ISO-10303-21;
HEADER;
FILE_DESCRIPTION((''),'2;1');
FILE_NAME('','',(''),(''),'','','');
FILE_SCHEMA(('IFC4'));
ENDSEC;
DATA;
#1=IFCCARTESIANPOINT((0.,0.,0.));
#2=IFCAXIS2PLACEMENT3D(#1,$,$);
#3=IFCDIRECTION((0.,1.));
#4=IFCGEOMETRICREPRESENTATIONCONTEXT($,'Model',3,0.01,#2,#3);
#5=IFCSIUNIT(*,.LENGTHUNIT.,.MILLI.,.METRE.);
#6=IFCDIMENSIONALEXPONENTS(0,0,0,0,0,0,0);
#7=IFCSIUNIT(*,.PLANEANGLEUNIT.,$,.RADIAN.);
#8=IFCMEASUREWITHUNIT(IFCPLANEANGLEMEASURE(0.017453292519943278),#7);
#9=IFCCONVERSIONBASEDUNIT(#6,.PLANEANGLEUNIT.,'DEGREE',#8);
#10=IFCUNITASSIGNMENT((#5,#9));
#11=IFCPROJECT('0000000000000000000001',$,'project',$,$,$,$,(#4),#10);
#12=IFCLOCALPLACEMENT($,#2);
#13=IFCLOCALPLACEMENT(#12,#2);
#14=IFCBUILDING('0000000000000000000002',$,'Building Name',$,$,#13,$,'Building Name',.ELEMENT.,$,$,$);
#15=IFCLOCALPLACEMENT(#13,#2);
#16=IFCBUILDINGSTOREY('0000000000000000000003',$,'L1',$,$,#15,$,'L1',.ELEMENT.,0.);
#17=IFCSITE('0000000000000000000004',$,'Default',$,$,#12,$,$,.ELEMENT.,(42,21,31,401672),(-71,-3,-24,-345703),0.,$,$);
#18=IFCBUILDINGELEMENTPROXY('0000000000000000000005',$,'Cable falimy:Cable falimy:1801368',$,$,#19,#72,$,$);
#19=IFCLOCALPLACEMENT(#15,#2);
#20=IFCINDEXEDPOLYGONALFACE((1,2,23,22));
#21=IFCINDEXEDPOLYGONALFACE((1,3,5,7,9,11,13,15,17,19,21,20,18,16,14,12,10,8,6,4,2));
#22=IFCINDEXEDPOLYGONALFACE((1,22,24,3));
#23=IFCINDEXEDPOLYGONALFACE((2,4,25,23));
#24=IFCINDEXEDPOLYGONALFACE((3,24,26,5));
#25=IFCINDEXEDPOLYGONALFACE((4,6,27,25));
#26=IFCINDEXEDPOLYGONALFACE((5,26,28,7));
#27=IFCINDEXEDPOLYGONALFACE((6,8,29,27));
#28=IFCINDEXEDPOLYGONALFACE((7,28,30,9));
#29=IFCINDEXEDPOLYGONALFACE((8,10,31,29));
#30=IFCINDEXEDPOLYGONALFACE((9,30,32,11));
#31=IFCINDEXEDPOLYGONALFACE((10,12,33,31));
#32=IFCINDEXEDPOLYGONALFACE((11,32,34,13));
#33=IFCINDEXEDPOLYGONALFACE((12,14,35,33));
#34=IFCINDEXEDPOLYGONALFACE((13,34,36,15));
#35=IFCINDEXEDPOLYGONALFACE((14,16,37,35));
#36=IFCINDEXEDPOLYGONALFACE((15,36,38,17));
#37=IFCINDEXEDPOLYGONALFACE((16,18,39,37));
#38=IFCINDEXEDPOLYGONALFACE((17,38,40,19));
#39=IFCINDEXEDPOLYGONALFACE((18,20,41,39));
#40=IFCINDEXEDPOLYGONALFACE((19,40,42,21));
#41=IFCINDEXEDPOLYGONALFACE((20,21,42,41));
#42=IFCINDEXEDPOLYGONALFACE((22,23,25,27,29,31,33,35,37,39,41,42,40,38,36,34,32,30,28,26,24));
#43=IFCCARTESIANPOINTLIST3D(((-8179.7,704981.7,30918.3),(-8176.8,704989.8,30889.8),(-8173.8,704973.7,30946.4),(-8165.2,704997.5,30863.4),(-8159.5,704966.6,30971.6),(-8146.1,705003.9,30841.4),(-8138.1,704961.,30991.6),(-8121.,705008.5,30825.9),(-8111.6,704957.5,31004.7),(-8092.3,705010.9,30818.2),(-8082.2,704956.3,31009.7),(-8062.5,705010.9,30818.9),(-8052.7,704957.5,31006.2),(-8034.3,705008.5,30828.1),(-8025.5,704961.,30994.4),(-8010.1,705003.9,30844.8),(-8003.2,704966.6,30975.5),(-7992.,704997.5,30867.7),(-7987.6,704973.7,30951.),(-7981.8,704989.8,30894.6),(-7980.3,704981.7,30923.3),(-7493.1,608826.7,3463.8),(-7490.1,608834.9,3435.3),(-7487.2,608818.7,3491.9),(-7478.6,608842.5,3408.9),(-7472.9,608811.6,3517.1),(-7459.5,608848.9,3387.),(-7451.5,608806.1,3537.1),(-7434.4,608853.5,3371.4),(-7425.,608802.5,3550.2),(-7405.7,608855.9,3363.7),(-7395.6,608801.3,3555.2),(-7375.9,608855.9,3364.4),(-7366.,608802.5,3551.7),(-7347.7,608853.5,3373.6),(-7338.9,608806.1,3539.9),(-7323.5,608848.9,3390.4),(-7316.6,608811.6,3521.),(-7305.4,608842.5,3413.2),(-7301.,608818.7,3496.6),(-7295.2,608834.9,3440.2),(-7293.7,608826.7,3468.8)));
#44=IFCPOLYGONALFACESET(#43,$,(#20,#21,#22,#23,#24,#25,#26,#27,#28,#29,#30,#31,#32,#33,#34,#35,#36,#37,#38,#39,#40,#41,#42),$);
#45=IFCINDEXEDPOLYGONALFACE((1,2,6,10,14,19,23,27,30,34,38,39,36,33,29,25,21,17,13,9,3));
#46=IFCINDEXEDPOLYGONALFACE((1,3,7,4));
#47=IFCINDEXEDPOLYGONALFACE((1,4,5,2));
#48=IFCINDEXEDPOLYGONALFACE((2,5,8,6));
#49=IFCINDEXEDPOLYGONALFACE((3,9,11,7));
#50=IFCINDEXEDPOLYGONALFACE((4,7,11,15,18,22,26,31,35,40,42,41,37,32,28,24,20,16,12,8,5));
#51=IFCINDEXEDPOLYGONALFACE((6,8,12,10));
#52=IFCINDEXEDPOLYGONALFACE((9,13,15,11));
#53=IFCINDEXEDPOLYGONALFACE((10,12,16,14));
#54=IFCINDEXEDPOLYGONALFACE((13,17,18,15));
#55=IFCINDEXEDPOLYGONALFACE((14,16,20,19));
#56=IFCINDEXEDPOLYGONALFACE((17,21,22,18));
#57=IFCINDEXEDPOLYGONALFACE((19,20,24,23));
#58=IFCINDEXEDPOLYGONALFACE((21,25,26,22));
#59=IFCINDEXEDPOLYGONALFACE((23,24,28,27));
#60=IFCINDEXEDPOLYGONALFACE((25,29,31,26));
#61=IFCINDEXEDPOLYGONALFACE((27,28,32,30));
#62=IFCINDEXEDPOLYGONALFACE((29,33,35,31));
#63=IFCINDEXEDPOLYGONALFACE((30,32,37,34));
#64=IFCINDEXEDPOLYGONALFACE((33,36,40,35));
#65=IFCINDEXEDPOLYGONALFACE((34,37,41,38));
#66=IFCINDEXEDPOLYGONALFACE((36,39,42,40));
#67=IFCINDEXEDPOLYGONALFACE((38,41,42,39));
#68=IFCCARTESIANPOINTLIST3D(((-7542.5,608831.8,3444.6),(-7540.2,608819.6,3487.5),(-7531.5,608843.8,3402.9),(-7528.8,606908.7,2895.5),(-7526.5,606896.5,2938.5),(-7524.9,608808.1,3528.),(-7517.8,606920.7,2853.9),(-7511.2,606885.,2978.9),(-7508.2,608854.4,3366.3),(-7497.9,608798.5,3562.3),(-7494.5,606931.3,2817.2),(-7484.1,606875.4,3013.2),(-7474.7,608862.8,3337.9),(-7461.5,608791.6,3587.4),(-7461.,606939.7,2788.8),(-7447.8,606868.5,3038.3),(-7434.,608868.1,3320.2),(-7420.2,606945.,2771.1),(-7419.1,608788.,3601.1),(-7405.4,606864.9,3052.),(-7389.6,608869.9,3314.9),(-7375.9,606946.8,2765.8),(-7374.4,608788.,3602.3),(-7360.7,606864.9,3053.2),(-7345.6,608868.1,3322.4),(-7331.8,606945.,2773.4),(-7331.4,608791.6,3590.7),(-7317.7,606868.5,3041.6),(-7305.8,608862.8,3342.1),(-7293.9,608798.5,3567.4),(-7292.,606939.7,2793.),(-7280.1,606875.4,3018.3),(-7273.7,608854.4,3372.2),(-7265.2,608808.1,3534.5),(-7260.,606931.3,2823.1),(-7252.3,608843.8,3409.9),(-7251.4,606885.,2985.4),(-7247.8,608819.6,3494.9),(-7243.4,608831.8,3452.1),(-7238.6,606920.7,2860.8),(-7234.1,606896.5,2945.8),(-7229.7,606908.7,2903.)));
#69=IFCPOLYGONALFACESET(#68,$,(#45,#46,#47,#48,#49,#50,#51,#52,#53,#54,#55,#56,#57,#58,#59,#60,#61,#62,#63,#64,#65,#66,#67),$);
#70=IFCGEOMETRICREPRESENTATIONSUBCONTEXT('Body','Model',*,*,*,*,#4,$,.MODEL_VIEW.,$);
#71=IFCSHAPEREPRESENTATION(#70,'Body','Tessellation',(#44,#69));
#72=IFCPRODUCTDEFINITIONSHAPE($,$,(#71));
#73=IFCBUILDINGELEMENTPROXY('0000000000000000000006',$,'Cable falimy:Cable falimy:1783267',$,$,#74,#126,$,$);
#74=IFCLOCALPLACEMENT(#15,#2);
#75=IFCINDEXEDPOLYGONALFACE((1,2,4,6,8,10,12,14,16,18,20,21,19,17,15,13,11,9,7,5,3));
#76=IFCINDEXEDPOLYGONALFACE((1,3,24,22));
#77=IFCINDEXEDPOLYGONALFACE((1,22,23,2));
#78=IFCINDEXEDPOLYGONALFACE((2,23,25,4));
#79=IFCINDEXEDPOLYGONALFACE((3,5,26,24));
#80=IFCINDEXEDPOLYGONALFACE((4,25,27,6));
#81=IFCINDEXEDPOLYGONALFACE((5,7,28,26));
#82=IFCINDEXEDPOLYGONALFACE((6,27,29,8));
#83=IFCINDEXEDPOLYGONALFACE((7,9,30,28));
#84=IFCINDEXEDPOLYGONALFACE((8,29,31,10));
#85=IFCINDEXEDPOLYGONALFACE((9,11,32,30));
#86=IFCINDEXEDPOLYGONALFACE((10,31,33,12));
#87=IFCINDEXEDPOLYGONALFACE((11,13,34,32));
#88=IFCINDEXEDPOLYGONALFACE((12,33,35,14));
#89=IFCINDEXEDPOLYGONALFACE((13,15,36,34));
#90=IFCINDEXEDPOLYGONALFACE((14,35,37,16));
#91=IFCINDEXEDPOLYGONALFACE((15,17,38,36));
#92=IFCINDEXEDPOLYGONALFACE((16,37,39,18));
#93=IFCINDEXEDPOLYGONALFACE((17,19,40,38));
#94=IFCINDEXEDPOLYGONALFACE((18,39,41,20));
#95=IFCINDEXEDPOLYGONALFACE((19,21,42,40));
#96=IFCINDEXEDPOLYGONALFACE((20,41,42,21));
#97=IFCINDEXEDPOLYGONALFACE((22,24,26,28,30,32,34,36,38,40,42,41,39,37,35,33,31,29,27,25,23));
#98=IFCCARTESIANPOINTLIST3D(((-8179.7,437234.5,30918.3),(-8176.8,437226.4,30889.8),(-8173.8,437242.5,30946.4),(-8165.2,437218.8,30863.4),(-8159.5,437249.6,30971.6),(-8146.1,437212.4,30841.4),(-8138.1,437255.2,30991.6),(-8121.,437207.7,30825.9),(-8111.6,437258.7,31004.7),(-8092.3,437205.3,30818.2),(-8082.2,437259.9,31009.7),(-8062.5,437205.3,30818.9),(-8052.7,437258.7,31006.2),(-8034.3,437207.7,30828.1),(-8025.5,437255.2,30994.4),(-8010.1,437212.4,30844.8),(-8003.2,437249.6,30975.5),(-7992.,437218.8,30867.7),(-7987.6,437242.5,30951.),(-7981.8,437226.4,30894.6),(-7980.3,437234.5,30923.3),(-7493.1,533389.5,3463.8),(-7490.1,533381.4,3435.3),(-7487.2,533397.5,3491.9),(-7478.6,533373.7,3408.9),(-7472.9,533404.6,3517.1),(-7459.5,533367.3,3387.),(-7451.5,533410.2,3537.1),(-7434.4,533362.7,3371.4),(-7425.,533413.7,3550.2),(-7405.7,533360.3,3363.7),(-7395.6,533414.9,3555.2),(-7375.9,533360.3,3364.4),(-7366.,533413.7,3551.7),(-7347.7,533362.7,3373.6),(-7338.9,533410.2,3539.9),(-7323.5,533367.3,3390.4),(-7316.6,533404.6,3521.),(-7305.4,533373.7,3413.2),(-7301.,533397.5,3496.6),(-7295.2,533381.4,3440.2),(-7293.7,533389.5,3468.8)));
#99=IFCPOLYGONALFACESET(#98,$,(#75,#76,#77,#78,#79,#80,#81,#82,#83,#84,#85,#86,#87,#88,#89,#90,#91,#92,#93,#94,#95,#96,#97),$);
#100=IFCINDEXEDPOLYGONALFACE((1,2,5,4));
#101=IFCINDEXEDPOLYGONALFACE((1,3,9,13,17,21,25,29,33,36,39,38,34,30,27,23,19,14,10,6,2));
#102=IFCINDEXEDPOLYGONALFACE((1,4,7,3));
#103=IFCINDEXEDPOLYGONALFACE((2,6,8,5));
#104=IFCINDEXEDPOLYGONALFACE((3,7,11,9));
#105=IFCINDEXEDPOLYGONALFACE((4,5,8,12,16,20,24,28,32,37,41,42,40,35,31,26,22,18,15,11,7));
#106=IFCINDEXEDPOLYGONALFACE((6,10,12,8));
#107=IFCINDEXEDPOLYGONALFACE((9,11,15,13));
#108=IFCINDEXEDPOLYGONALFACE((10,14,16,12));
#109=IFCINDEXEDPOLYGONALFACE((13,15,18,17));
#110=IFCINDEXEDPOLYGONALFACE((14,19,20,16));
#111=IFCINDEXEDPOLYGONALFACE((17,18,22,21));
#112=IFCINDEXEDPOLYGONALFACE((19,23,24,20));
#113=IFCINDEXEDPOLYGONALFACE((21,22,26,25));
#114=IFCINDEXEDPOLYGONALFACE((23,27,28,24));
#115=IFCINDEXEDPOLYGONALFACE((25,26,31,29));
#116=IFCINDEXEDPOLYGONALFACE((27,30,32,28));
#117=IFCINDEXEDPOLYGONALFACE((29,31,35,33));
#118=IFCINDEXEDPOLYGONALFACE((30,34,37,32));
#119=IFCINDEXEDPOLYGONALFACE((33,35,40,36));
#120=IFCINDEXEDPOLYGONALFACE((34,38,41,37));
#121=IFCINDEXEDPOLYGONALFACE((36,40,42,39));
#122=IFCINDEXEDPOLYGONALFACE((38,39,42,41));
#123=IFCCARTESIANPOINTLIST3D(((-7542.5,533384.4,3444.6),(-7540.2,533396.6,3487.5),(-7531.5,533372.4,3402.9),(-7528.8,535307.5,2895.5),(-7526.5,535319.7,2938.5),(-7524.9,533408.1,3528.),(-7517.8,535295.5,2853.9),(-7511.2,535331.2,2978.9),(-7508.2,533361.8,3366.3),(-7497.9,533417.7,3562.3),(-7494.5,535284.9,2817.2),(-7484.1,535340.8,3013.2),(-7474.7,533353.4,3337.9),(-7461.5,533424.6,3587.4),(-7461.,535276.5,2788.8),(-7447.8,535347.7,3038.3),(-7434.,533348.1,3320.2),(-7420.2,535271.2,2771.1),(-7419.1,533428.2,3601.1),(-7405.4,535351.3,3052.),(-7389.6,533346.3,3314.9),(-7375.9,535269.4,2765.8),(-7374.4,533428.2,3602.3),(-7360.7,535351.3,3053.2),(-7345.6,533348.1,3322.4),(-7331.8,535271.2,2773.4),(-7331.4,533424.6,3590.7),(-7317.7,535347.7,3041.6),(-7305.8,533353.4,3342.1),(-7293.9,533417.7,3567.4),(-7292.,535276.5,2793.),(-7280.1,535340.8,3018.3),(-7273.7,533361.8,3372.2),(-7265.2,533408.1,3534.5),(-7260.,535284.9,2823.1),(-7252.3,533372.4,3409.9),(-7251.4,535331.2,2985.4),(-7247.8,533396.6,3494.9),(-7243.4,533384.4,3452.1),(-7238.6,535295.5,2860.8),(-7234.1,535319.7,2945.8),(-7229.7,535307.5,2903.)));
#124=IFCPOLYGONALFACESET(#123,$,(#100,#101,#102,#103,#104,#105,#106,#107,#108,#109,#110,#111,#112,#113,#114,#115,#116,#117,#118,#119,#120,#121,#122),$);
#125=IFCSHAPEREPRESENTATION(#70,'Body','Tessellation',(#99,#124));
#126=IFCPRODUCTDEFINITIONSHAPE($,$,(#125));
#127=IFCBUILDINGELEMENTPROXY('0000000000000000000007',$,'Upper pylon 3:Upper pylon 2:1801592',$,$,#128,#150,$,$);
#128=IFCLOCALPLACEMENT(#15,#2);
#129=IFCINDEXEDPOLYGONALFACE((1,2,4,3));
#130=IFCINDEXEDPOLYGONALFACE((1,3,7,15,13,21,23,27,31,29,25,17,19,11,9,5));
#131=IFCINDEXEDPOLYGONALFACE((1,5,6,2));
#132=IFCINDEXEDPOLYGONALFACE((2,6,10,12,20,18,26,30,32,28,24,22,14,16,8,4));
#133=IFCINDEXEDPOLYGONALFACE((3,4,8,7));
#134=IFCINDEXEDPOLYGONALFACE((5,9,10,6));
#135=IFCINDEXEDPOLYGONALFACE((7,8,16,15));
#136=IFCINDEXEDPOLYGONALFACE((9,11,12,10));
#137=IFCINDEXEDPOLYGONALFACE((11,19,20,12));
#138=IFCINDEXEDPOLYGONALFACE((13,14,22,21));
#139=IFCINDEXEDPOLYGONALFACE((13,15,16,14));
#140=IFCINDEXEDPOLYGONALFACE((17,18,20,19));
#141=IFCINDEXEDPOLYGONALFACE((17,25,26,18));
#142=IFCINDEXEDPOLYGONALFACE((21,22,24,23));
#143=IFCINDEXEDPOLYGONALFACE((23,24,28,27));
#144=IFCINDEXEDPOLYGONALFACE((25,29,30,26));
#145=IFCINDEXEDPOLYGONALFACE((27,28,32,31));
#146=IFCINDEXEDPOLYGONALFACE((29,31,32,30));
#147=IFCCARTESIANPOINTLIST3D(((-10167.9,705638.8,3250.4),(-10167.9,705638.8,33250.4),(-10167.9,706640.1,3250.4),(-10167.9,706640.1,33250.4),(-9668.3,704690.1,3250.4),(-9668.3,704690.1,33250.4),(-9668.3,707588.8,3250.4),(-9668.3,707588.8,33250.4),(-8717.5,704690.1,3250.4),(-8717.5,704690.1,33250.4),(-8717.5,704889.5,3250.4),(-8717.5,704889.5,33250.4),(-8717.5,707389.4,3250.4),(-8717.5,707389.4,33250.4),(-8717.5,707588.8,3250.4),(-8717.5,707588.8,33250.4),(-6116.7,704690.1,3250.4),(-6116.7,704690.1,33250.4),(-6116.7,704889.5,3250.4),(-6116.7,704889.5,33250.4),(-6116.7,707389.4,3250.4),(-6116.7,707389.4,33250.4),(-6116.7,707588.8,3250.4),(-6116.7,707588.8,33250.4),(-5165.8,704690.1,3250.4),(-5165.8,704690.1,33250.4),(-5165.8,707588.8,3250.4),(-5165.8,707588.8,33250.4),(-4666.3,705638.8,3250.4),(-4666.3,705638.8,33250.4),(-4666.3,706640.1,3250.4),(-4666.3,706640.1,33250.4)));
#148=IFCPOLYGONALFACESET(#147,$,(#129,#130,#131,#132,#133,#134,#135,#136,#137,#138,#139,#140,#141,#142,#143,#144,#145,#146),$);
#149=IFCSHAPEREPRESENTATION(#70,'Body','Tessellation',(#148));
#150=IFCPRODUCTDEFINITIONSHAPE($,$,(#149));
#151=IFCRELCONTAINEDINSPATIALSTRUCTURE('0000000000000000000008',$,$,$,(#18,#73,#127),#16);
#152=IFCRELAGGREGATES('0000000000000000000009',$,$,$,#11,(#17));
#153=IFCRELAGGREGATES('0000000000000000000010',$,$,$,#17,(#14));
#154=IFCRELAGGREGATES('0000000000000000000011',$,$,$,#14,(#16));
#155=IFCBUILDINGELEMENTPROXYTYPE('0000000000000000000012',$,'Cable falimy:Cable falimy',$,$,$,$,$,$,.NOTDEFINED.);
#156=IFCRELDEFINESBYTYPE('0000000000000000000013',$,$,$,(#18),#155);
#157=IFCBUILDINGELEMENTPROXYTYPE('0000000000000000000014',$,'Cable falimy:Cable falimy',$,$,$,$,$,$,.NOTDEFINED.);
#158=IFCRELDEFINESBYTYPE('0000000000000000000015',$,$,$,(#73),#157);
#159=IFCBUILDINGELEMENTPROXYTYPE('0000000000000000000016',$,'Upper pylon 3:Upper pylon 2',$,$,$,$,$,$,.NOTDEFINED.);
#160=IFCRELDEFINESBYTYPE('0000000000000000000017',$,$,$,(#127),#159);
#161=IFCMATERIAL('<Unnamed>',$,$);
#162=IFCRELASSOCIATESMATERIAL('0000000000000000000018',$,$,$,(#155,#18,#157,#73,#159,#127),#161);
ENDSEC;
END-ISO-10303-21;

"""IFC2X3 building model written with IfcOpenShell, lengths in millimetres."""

from ifc_helpers import new_model, entity, si_unit, converted_unit, direction, frame, frame_2d, origin, place, context, subcontext, project, spatial, polyline, circle, outline, extrude, source, transform, mapped, material, type_object, type_shapes, element, save


model = new_model("IFC2X3")

# Units and contexts
model_context = context("Model", 3, precision=0.01, world=origin(), true_north=direction((0.0, 1.0)))
body_context = subcontext(model_context, "Body", "Model", "MODEL_VIEW")
ifc_project = project(units=[si_unit("LENGTHUNIT", "METRE", prefix="MILLI"), converted_unit("PLANEANGLEUNIT", "DEGREE", entity("IfcPlaneAngleMeasure", 0.017453292519943278), si_unit("PLANEANGLEUNIT", "RADIAN"), dimensions=[0, 0, 0, 0, 0, 0, 0])], contexts=[model_context])

# Site, building, storey
site_placement = place(None, origin())
site = spatial("IfcSite", under=ifc_project, at=site_placement, Name="Default", CompositionType="ELEMENT", RefLatitude=(42, 21, 31, 401672), RefLongitude=(-71, -3, -24, -345703), RefElevation=0.0)
building_placement = place(site_placement, origin())
building = spatial("IfcBuilding", under=site, at=building_placement, Name="Building Name", LongName="Building Name", CompositionType="ELEMENT")
storey_placement = place(building_placement, origin())
storey = spatial("IfcBuildingStorey", under=building, at=storey_placement, Name="L1", LongName="L1", CompositionType="ELEMENT", Elevation=0.0)

# Shared definitions
ifc_material = material(Name="<Unnamed>")

# Building element proxies
building_element_proxy_type_1 = type_object("IfcBuildingElementProxyType", Name="Cable falimy:Cable falimy", PredefinedType="NOTDEFINED", material=ifc_material)
shared_shape_1 = source(origin(), body_context, "Body", "SweptSolid", [
    extrude(circle(Radius=100.0, at=frame_2d((0.0, 0.0), x_axis=(1.0, 0.0))), frame((0.0, 0.0, 0.0), z_axis=(0.96155, 0.0, 0.274631), x_axis=(-0.274631, 0.0, 0.96155)), (0.0, 0.0, 1.0), 100000.0),
    extrude(circle(Radius=150.0, at=frame_2d((0.0, 0.0), x_axis=(1.0, 0.0))), frame((-1923.1, 0.0, -549.3), z_axis=(0.96155, 0.0, 0.274631), x_axis=(0.274631, 0.0, -0.96155)), (0.0, 0.0, 1.0), 2000.0),
])
type_shapes(building_element_proxy_type_1, [shared_shape_1])
proxy_1_placement = place(storey_placement, frame((-7393.2, 608828.7, 3459.1), z_axis=(-0.025001, 0.0, 0.999687), x_axis=(0.0, 1.0, 0.0)))
element("IfcBuildingElementProxy", 1, at=proxy_1_placement, inside=storey, type_object=building_element_proxy_type_1, material=ifc_material, Name="Cable falimy:Cable falimy:1801368", context=body_context, shape_type="MappedRepresentation", body=[
    mapped(shared_shape_1, transform((0.0, 0.0, 0.0), scale=1.0)),
])
building_element_proxy_type_2 = type_object("IfcBuildingElementProxyType", Name="Cable falimy:Cable falimy", PredefinedType="NOTDEFINED", material=ifc_material)
shared_shape_2 = source(origin(), body_context, "Body", "SweptSolid", [
    extrude(circle(Radius=100.0, at=frame_2d((0.0, 0.0), x_axis=(1.0, 0.0))), frame((0.0, 0.0, 0.0), z_axis=(0.96155, 0.0, 0.274631), x_axis=(-0.274631, 0.0, 0.96155)), (0.0, 0.0, 1.0), 100000.0),
    extrude(circle(Radius=150.0, at=frame_2d((0.0, 0.0), x_axis=(1.0, 0.0))), frame((-1923.1, 0.0, -549.3), z_axis=(0.96155, 0.0, 0.274631), x_axis=(0.274631, 0.0, -0.96155)), (0.0, 0.0, 1.0), 2000.0),
])
type_shapes(building_element_proxy_type_2, [shared_shape_2])
proxy_2_placement = place(storey_placement, frame((-7393.2, 533387.5, 3459.1), z_axis=(-0.025001, 0.0, 0.999687), x_axis=(0.0, -1.0, 0.0)))
element("IfcBuildingElementProxy", 2, at=proxy_2_placement, inside=storey, type_object=building_element_proxy_type_2, material=ifc_material, Name="Cable falimy:Cable falimy:1783267", context=body_context, shape_type="MappedRepresentation", body=[
    mapped(shared_shape_2, transform((0.0, 0.0, 0.0), scale=1.0)),
])
building_element_proxy_type_3 = type_object("IfcBuildingElementProxyType", Name="Upper pylon 3:Upper pylon 2", PredefinedType="NOTDEFINED", material=ifc_material)
shared_shape_3 = source(origin(), body_context, "Body", "SweptSolid", [
    extrude(outline(polyline([(1300.4, -1449.3), (2251.3, -1449.3), (2750.8, -500.6), (2750.8, 500.6), (2251.3, 1449.3), (1300.4, 1449.3), (1300.4, 1249.9), (-1300.4, 1249.9), (-1300.4, 1449.3), (-2251.3, 1449.3), (-2750.8, 500.6), (-2750.8, -500.6), (-2251.3, -1449.3), (-1300.4, -1449.3), (-1300.4, -1249.9), (1300.4, -1249.9), (1300.4, -1449.3)])), frame((68629.5, 106372.9, 3609.7), z_axis=(0.0, 0.0, 1.0), x_axis=(-1.0, 0.0, 0.0)), (0.0, 0.0, 1.0), 30000.0),
])
type_shapes(building_element_proxy_type_3, [shared_shape_3])
proxy_3_placement = place(storey_placement, frame((-76046.6, 599766.5, -359.3)))
element("IfcBuildingElementProxy", 3, at=proxy_3_placement, inside=storey, type_object=building_element_proxy_type_3, material=ifc_material, Name="Upper pylon 3:Upper pylon 2:1801592", context=body_context, shape_type="MappedRepresentation", body=[
    mapped(shared_shape_3, transform((0.0, 0.0, 0.0), scale=1.0)),
])

save(model, "model.ifc")
